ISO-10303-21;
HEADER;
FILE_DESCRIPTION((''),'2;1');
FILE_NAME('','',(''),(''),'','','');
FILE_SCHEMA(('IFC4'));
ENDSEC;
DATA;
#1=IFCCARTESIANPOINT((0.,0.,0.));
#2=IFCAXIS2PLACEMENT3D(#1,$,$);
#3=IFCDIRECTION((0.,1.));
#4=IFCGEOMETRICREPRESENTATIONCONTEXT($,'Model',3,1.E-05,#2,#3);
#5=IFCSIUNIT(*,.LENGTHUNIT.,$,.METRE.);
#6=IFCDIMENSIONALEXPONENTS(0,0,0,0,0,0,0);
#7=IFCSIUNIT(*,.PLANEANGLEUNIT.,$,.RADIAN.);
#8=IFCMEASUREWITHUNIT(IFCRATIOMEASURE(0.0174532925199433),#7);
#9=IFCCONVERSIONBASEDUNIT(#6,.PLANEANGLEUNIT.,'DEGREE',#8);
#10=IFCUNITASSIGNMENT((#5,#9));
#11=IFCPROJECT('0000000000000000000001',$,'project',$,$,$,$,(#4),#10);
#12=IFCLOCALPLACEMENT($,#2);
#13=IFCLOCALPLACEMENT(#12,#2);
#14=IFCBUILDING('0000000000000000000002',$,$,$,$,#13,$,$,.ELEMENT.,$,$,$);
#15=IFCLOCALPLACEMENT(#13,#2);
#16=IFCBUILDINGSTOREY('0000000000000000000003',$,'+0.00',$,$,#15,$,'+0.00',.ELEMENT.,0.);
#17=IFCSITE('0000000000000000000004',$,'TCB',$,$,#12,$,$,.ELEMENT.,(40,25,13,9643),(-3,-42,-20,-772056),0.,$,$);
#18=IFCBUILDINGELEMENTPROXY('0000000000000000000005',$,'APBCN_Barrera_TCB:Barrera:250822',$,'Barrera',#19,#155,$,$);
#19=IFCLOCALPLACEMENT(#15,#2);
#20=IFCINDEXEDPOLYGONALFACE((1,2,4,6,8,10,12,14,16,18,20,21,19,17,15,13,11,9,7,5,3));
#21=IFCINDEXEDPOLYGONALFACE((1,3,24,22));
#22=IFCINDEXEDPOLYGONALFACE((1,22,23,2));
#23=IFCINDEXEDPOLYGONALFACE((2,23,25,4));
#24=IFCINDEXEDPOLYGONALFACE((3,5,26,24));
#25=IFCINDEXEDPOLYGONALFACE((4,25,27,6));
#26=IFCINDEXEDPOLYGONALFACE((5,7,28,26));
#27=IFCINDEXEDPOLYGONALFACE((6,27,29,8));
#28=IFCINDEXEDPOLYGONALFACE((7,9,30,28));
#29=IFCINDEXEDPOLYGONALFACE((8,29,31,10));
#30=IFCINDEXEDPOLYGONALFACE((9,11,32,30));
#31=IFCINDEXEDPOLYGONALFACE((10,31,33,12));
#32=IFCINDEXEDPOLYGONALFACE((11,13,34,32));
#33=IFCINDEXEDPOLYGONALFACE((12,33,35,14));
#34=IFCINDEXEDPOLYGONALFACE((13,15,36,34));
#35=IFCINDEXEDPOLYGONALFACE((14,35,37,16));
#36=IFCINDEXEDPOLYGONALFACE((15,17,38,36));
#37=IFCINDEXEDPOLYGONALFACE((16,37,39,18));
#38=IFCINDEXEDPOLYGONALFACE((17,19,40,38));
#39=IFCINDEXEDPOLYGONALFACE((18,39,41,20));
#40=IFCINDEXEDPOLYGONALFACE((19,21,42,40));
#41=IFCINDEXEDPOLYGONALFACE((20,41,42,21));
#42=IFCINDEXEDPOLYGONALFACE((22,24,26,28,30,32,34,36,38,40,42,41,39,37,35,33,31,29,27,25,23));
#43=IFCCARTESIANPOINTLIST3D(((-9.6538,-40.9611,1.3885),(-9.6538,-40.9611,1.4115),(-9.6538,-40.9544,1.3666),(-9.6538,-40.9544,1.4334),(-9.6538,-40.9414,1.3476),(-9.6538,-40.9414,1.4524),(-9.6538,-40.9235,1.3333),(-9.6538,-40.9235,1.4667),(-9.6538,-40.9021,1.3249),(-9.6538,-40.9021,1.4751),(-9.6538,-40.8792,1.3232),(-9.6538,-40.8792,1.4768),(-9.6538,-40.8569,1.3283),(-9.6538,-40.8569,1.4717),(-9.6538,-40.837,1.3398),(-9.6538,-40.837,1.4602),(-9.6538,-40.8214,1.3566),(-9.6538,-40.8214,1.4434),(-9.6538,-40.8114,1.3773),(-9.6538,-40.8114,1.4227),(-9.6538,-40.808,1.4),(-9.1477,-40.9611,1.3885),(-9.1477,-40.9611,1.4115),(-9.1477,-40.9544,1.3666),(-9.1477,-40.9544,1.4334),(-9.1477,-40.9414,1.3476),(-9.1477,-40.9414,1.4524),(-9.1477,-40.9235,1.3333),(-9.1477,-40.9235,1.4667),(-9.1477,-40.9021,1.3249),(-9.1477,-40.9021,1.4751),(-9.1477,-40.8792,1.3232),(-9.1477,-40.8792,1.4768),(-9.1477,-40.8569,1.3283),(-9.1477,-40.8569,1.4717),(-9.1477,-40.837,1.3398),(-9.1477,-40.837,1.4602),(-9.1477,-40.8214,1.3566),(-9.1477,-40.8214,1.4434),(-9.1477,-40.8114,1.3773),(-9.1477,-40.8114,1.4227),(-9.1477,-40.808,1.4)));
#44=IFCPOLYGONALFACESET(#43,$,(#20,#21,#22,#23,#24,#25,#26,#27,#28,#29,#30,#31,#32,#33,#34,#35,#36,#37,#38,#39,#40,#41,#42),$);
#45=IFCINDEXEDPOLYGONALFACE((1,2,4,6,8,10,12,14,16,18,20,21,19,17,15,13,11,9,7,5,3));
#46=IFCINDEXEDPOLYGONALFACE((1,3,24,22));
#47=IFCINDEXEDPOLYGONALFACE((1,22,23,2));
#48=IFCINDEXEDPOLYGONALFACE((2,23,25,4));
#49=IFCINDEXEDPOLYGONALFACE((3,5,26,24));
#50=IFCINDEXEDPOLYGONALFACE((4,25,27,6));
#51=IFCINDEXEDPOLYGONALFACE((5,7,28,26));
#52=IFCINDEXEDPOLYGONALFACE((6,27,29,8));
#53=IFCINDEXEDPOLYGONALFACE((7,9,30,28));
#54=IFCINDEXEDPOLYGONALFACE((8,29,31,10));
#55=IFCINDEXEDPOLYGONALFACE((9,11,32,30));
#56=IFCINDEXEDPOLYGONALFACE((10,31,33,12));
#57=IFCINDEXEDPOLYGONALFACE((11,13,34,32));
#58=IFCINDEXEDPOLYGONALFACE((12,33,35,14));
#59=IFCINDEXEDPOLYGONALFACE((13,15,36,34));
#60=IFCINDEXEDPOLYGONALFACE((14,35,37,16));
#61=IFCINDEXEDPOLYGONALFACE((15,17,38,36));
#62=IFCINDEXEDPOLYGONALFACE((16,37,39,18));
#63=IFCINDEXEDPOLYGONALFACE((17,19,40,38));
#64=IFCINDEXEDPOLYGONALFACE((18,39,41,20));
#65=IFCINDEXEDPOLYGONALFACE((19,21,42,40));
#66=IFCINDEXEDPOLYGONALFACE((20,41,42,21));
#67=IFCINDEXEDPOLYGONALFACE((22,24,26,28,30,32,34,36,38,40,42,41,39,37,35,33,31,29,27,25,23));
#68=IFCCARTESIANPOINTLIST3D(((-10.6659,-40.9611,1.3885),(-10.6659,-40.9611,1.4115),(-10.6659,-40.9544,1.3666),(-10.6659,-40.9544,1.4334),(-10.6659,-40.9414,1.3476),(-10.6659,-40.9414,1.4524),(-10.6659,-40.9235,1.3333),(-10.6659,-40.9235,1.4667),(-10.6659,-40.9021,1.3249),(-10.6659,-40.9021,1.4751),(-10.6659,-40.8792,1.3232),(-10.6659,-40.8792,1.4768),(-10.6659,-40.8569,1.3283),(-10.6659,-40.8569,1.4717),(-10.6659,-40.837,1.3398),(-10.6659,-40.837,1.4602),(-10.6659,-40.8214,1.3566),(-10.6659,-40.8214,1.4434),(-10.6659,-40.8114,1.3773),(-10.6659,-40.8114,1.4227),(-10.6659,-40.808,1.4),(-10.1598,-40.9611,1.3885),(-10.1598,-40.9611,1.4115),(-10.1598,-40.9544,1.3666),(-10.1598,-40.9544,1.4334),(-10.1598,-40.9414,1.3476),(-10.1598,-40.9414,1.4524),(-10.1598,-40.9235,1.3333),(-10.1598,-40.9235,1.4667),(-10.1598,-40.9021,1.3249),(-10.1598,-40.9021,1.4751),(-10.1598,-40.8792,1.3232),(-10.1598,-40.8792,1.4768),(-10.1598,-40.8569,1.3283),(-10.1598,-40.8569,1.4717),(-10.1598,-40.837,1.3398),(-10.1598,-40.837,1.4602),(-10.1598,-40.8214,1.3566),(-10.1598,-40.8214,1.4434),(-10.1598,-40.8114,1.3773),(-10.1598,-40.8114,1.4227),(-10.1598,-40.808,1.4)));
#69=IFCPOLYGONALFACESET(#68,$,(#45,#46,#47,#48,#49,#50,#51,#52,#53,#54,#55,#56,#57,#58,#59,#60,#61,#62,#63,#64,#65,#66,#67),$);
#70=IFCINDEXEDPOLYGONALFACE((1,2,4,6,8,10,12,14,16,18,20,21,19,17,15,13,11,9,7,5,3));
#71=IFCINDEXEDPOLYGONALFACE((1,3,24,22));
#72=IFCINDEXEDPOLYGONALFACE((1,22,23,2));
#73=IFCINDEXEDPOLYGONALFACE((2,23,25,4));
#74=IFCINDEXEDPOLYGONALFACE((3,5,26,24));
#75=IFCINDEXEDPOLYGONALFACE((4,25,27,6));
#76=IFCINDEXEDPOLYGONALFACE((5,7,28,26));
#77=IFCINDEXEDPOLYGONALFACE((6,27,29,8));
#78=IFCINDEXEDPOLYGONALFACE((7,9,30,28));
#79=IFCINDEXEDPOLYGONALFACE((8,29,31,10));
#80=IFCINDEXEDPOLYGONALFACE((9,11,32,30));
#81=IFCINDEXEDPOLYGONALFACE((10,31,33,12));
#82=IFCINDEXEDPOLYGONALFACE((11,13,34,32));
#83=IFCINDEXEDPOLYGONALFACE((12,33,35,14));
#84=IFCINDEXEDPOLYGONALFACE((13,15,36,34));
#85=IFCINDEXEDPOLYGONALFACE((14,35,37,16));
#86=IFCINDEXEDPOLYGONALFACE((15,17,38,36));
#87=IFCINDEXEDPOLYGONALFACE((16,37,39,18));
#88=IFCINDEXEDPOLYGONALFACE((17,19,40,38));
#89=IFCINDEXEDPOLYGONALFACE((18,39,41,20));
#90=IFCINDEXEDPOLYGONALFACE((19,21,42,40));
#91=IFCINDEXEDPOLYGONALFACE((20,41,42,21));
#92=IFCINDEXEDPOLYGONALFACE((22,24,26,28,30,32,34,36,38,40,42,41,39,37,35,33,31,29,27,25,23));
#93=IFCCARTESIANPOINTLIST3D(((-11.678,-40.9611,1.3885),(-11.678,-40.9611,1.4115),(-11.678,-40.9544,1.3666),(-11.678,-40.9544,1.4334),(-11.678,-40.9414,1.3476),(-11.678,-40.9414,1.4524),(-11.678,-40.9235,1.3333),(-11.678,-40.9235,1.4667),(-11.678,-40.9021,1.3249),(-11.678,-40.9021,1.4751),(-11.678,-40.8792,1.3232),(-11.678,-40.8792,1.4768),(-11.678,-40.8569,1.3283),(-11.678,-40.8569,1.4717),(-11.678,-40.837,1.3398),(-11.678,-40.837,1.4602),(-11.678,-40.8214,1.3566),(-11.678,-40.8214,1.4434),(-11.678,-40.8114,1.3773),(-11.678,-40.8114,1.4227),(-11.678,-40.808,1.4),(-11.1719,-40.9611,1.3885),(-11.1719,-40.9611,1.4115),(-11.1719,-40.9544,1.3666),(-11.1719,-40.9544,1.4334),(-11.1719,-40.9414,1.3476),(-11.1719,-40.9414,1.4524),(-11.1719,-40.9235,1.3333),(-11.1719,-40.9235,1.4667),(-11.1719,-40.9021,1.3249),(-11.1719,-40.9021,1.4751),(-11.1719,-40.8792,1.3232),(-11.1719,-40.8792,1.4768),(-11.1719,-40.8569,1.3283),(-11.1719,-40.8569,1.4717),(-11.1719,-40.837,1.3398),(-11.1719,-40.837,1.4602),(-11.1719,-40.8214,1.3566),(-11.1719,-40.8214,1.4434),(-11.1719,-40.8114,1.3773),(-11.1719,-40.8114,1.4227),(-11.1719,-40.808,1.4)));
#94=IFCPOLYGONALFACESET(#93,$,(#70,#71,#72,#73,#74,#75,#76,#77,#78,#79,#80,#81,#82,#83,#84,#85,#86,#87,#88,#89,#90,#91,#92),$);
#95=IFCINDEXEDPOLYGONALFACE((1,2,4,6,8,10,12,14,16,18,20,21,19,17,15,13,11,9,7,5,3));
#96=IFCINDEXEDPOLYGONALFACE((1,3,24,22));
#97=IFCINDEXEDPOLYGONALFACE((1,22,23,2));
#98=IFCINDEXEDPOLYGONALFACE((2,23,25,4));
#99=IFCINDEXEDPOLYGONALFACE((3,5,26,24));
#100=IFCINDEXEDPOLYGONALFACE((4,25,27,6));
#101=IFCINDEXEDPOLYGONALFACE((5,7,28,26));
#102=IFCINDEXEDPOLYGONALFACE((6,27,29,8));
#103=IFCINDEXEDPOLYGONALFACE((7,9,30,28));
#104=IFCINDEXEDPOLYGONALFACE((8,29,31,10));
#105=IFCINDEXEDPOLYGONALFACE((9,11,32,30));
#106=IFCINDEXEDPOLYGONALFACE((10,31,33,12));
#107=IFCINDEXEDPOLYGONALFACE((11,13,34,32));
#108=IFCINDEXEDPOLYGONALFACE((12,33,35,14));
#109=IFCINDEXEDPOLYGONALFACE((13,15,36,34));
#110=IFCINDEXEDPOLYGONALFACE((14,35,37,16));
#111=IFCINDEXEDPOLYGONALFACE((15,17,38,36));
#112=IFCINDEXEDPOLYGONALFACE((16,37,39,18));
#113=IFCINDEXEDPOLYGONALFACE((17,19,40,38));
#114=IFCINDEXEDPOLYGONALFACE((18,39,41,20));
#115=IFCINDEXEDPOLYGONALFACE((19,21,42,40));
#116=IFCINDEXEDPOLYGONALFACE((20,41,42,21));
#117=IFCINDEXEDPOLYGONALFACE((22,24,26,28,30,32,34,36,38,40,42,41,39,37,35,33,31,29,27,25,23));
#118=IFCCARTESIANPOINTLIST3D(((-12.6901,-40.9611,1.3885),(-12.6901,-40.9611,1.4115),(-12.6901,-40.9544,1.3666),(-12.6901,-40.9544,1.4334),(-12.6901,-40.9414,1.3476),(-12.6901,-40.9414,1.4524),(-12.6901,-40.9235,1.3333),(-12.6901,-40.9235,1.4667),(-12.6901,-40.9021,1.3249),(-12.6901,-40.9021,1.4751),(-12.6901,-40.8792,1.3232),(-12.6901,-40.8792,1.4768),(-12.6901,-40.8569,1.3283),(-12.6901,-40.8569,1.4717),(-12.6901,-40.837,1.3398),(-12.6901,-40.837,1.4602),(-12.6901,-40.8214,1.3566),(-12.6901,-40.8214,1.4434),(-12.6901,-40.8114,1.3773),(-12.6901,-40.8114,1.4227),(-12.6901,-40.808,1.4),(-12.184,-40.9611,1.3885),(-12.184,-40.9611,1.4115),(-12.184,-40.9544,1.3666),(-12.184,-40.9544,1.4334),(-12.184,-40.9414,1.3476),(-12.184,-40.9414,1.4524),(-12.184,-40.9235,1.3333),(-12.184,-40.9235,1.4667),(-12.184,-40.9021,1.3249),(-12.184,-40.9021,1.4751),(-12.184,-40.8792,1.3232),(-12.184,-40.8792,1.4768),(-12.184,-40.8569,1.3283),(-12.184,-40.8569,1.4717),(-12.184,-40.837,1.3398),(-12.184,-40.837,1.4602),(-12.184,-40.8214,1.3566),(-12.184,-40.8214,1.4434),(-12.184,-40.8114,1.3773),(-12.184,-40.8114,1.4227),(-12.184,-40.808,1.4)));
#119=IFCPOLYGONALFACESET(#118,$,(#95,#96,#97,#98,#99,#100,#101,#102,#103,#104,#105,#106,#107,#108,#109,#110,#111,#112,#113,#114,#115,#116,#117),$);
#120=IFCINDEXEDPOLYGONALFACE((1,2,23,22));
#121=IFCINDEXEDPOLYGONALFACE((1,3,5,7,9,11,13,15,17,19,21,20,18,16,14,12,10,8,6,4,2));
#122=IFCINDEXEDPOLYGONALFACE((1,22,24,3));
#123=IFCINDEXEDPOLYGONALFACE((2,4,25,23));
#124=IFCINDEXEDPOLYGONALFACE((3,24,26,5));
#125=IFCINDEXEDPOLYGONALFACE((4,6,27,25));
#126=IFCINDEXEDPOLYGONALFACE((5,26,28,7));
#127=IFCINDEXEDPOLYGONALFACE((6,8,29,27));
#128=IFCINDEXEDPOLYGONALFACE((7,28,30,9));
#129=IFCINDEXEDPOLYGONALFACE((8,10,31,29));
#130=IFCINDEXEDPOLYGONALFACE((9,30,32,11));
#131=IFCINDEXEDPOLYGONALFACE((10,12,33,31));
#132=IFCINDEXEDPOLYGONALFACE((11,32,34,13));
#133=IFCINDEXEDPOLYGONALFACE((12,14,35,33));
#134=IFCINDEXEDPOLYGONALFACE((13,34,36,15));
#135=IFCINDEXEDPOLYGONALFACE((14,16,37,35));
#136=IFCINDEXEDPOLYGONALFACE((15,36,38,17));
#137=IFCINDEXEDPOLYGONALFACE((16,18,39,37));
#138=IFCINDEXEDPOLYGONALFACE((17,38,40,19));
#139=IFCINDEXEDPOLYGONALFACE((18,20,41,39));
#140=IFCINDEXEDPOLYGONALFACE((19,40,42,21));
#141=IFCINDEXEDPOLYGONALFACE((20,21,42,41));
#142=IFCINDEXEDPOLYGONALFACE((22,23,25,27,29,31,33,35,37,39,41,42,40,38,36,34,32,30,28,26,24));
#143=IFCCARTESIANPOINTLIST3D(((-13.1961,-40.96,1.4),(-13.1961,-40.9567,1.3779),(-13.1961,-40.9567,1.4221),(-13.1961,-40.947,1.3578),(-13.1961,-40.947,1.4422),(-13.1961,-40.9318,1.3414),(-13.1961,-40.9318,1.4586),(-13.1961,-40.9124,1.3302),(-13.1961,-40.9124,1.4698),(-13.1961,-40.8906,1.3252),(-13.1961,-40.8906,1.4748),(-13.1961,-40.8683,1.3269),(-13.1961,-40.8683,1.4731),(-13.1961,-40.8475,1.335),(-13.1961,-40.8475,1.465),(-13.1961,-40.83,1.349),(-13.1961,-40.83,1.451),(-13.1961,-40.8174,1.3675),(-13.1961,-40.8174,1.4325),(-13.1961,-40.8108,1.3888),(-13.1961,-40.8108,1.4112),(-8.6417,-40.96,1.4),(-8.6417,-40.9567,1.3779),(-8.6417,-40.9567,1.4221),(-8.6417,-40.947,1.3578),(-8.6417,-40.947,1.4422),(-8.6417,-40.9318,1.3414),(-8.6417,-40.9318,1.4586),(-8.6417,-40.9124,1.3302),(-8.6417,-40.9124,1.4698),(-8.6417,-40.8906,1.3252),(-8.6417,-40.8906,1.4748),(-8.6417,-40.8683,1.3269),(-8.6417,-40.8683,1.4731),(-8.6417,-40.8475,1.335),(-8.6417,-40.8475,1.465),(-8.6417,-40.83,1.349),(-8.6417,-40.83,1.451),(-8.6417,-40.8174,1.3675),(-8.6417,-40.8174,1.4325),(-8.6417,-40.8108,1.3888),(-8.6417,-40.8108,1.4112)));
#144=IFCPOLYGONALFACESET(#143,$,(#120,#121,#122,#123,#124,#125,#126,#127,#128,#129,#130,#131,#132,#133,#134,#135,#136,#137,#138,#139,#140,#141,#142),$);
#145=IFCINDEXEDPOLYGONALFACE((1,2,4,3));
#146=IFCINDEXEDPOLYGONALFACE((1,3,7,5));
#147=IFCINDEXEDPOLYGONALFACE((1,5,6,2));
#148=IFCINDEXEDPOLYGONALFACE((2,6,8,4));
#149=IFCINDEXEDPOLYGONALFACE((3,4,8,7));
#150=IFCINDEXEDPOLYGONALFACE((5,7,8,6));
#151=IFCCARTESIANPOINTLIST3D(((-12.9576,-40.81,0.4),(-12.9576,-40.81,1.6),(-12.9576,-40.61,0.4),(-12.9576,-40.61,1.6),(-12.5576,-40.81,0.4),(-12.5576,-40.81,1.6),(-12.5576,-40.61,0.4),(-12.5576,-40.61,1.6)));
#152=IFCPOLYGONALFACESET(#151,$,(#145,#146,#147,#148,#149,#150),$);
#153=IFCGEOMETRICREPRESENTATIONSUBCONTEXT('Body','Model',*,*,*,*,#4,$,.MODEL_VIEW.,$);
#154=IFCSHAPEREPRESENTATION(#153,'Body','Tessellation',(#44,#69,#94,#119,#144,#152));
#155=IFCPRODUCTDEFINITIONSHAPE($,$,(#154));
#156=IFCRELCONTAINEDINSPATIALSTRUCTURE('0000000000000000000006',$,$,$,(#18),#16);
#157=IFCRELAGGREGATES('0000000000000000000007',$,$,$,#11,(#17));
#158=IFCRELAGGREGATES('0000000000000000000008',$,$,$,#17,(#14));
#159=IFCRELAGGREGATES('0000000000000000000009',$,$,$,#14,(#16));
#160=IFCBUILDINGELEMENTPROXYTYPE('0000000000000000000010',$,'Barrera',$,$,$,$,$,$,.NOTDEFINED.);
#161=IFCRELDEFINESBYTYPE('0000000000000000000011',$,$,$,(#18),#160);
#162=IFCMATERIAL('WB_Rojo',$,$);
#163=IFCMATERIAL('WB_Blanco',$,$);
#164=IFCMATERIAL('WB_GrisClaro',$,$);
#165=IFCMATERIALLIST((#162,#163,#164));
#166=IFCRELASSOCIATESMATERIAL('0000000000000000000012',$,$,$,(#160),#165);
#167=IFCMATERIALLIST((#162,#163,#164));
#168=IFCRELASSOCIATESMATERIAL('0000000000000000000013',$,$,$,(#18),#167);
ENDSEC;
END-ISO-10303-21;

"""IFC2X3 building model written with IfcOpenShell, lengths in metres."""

from ifc_helpers import new_model, entity, si_unit, converted_unit, direction, frame, frame_2d, origin, place, context, subcontext, project, spatial, rectangle, circle, extrude, source, transform, mapped, material, material_list, type_object, type_shapes, element, save


model = new_model("IFC2X3")

# Units and contexts
model_context = context("Model", 3, precision=1e-05, world=origin(), true_north=direction((0.0, 1.0)))
body_context = subcontext(model_context, "Body", "Model", "MODEL_VIEW")
ifc_project = project(units=[si_unit("LENGTHUNIT", "METRE"), converted_unit("PLANEANGLEUNIT", "DEGREE", entity("IfcRatioMeasure", 0.0174532925199433), si_unit("PLANEANGLEUNIT", "RADIAN"), dimensions=[0, 0, 0, 0, 0, 0, 0])], contexts=[model_context])

# Site, building, storey
site_placement = place(None, origin())
site = spatial("IfcSite", under=ifc_project, at=site_placement, Name="TCB", CompositionType="ELEMENT", RefLatitude=(40, 25, 13, 9643), RefLongitude=(-3, -42, -20, -772056), RefElevation=0.0)
building_placement = place(site_placement, origin())
building = spatial("IfcBuilding", under=site, at=building_placement, CompositionType="ELEMENT")
storey_placement = place(building_placement, origin())
storey = spatial("IfcBuildingStorey", under=building, at=storey_placement, Name="+0.00", LongName="+0.00", CompositionType="ELEMENT", Elevation=0.0)

# Shared definitions
ifc_material_1 = material(Name="WB_GrisClaro")

# Building element proxy
ifc_material_2 = material(Name="WB_Rojo")
ifc_material_3 = material(Name="WB_Blanco")
ifc_material_list_1 = material_list([ifc_material_2, ifc_material_3, ifc_material_1])
building_element_proxy_type_1 = type_object("IfcBuildingElementProxyType", Name="Barrera", PredefinedType="NOTDEFINED", material=ifc_material_list_1)
shared_shape_1 = source(origin(), body_context, "Body", "SweptSolid", [
    extrude(circle(Radius=0.077, at=frame_2d((0.0, 0.0), x_axis=(1.0, 0.0))), frame((2.8039, -0.175, 1.0), z_axis=(1.0, 0.0, 0.0), x_axis=(0.0, 1.0, 0.0)), (0.0, 0.0, 1.0), 0.506),
    extrude(circle(Radius=0.077, at=frame_2d((0.0, 0.0), x_axis=(1.0, 0.0))), frame((1.7918, -0.175, 1.0), z_axis=(1.0, 0.0, 0.0), x_axis=(0.0, 1.0, 0.0)), (0.0, 0.0, 1.0), 0.506),
    extrude(circle(Radius=0.077, at=frame_2d((0.0, 0.0), x_axis=(1.0, 0.0))), frame((0.7797, -0.175, 1.0), z_axis=(1.0, 0.0, 0.0), x_axis=(0.0, 1.0, 0.0)), (0.0, 0.0, 1.0), 0.506),
    extrude(circle(Radius=0.077, at=frame_2d((0.0, 0.0), x_axis=(1.0, 0.0))), frame((-0.2324, -0.175, 1.0), z_axis=(1.0, 0.0, 0.0), x_axis=(0.0, 1.0, 0.0)), (0.0, 0.0, 1.0), 0.506),
    extrude(circle(Radius=0.075, at=frame_2d((0.0, 0.0), x_axis=(1.0, 0.0))), frame((-0.7385, -0.175, 1.0), z_axis=(1.0, 0.0, 0.0), x_axis=(0.0, -1.0, 0.0)), (0.0, 0.0, 1.0), 4.5544),
    extrude(rectangle(XDim=0.2, YDim=0.4, at=frame_2d((0.0, 0.0), x_axis=(1.0, 0.0))), frame((-0.3, 0.0, 0.0), z_axis=(0.0, 0.0, 1.0), x_axis=(0.0, -1.0, 0.0)), (0.0, 0.0, 1.0), 1.2),
])
type_shapes(building_element_proxy_type_1, [shared_shape_1])
ifc_material_list_2 = material_list([ifc_material_2, ifc_material_3, ifc_material_1])
proxy_1_placement = place(storey_placement, frame((-12.4576, -40.71, 0.4)))
element("IfcBuildingElementProxy", 1, at=proxy_1_placement, inside=storey, type_object=building_element_proxy_type_1, material=ifc_material_list_2, Name="APBCN_Barrera_TCB:Barrera:250822", ObjectType="Barrera", context=body_context, shape_type="MappedRepresentation", body=[
    mapped(shared_shape_1, transform((0.0, 0.0, 0.0), scale=1.0)),
])

save(model, "model.ifc")
